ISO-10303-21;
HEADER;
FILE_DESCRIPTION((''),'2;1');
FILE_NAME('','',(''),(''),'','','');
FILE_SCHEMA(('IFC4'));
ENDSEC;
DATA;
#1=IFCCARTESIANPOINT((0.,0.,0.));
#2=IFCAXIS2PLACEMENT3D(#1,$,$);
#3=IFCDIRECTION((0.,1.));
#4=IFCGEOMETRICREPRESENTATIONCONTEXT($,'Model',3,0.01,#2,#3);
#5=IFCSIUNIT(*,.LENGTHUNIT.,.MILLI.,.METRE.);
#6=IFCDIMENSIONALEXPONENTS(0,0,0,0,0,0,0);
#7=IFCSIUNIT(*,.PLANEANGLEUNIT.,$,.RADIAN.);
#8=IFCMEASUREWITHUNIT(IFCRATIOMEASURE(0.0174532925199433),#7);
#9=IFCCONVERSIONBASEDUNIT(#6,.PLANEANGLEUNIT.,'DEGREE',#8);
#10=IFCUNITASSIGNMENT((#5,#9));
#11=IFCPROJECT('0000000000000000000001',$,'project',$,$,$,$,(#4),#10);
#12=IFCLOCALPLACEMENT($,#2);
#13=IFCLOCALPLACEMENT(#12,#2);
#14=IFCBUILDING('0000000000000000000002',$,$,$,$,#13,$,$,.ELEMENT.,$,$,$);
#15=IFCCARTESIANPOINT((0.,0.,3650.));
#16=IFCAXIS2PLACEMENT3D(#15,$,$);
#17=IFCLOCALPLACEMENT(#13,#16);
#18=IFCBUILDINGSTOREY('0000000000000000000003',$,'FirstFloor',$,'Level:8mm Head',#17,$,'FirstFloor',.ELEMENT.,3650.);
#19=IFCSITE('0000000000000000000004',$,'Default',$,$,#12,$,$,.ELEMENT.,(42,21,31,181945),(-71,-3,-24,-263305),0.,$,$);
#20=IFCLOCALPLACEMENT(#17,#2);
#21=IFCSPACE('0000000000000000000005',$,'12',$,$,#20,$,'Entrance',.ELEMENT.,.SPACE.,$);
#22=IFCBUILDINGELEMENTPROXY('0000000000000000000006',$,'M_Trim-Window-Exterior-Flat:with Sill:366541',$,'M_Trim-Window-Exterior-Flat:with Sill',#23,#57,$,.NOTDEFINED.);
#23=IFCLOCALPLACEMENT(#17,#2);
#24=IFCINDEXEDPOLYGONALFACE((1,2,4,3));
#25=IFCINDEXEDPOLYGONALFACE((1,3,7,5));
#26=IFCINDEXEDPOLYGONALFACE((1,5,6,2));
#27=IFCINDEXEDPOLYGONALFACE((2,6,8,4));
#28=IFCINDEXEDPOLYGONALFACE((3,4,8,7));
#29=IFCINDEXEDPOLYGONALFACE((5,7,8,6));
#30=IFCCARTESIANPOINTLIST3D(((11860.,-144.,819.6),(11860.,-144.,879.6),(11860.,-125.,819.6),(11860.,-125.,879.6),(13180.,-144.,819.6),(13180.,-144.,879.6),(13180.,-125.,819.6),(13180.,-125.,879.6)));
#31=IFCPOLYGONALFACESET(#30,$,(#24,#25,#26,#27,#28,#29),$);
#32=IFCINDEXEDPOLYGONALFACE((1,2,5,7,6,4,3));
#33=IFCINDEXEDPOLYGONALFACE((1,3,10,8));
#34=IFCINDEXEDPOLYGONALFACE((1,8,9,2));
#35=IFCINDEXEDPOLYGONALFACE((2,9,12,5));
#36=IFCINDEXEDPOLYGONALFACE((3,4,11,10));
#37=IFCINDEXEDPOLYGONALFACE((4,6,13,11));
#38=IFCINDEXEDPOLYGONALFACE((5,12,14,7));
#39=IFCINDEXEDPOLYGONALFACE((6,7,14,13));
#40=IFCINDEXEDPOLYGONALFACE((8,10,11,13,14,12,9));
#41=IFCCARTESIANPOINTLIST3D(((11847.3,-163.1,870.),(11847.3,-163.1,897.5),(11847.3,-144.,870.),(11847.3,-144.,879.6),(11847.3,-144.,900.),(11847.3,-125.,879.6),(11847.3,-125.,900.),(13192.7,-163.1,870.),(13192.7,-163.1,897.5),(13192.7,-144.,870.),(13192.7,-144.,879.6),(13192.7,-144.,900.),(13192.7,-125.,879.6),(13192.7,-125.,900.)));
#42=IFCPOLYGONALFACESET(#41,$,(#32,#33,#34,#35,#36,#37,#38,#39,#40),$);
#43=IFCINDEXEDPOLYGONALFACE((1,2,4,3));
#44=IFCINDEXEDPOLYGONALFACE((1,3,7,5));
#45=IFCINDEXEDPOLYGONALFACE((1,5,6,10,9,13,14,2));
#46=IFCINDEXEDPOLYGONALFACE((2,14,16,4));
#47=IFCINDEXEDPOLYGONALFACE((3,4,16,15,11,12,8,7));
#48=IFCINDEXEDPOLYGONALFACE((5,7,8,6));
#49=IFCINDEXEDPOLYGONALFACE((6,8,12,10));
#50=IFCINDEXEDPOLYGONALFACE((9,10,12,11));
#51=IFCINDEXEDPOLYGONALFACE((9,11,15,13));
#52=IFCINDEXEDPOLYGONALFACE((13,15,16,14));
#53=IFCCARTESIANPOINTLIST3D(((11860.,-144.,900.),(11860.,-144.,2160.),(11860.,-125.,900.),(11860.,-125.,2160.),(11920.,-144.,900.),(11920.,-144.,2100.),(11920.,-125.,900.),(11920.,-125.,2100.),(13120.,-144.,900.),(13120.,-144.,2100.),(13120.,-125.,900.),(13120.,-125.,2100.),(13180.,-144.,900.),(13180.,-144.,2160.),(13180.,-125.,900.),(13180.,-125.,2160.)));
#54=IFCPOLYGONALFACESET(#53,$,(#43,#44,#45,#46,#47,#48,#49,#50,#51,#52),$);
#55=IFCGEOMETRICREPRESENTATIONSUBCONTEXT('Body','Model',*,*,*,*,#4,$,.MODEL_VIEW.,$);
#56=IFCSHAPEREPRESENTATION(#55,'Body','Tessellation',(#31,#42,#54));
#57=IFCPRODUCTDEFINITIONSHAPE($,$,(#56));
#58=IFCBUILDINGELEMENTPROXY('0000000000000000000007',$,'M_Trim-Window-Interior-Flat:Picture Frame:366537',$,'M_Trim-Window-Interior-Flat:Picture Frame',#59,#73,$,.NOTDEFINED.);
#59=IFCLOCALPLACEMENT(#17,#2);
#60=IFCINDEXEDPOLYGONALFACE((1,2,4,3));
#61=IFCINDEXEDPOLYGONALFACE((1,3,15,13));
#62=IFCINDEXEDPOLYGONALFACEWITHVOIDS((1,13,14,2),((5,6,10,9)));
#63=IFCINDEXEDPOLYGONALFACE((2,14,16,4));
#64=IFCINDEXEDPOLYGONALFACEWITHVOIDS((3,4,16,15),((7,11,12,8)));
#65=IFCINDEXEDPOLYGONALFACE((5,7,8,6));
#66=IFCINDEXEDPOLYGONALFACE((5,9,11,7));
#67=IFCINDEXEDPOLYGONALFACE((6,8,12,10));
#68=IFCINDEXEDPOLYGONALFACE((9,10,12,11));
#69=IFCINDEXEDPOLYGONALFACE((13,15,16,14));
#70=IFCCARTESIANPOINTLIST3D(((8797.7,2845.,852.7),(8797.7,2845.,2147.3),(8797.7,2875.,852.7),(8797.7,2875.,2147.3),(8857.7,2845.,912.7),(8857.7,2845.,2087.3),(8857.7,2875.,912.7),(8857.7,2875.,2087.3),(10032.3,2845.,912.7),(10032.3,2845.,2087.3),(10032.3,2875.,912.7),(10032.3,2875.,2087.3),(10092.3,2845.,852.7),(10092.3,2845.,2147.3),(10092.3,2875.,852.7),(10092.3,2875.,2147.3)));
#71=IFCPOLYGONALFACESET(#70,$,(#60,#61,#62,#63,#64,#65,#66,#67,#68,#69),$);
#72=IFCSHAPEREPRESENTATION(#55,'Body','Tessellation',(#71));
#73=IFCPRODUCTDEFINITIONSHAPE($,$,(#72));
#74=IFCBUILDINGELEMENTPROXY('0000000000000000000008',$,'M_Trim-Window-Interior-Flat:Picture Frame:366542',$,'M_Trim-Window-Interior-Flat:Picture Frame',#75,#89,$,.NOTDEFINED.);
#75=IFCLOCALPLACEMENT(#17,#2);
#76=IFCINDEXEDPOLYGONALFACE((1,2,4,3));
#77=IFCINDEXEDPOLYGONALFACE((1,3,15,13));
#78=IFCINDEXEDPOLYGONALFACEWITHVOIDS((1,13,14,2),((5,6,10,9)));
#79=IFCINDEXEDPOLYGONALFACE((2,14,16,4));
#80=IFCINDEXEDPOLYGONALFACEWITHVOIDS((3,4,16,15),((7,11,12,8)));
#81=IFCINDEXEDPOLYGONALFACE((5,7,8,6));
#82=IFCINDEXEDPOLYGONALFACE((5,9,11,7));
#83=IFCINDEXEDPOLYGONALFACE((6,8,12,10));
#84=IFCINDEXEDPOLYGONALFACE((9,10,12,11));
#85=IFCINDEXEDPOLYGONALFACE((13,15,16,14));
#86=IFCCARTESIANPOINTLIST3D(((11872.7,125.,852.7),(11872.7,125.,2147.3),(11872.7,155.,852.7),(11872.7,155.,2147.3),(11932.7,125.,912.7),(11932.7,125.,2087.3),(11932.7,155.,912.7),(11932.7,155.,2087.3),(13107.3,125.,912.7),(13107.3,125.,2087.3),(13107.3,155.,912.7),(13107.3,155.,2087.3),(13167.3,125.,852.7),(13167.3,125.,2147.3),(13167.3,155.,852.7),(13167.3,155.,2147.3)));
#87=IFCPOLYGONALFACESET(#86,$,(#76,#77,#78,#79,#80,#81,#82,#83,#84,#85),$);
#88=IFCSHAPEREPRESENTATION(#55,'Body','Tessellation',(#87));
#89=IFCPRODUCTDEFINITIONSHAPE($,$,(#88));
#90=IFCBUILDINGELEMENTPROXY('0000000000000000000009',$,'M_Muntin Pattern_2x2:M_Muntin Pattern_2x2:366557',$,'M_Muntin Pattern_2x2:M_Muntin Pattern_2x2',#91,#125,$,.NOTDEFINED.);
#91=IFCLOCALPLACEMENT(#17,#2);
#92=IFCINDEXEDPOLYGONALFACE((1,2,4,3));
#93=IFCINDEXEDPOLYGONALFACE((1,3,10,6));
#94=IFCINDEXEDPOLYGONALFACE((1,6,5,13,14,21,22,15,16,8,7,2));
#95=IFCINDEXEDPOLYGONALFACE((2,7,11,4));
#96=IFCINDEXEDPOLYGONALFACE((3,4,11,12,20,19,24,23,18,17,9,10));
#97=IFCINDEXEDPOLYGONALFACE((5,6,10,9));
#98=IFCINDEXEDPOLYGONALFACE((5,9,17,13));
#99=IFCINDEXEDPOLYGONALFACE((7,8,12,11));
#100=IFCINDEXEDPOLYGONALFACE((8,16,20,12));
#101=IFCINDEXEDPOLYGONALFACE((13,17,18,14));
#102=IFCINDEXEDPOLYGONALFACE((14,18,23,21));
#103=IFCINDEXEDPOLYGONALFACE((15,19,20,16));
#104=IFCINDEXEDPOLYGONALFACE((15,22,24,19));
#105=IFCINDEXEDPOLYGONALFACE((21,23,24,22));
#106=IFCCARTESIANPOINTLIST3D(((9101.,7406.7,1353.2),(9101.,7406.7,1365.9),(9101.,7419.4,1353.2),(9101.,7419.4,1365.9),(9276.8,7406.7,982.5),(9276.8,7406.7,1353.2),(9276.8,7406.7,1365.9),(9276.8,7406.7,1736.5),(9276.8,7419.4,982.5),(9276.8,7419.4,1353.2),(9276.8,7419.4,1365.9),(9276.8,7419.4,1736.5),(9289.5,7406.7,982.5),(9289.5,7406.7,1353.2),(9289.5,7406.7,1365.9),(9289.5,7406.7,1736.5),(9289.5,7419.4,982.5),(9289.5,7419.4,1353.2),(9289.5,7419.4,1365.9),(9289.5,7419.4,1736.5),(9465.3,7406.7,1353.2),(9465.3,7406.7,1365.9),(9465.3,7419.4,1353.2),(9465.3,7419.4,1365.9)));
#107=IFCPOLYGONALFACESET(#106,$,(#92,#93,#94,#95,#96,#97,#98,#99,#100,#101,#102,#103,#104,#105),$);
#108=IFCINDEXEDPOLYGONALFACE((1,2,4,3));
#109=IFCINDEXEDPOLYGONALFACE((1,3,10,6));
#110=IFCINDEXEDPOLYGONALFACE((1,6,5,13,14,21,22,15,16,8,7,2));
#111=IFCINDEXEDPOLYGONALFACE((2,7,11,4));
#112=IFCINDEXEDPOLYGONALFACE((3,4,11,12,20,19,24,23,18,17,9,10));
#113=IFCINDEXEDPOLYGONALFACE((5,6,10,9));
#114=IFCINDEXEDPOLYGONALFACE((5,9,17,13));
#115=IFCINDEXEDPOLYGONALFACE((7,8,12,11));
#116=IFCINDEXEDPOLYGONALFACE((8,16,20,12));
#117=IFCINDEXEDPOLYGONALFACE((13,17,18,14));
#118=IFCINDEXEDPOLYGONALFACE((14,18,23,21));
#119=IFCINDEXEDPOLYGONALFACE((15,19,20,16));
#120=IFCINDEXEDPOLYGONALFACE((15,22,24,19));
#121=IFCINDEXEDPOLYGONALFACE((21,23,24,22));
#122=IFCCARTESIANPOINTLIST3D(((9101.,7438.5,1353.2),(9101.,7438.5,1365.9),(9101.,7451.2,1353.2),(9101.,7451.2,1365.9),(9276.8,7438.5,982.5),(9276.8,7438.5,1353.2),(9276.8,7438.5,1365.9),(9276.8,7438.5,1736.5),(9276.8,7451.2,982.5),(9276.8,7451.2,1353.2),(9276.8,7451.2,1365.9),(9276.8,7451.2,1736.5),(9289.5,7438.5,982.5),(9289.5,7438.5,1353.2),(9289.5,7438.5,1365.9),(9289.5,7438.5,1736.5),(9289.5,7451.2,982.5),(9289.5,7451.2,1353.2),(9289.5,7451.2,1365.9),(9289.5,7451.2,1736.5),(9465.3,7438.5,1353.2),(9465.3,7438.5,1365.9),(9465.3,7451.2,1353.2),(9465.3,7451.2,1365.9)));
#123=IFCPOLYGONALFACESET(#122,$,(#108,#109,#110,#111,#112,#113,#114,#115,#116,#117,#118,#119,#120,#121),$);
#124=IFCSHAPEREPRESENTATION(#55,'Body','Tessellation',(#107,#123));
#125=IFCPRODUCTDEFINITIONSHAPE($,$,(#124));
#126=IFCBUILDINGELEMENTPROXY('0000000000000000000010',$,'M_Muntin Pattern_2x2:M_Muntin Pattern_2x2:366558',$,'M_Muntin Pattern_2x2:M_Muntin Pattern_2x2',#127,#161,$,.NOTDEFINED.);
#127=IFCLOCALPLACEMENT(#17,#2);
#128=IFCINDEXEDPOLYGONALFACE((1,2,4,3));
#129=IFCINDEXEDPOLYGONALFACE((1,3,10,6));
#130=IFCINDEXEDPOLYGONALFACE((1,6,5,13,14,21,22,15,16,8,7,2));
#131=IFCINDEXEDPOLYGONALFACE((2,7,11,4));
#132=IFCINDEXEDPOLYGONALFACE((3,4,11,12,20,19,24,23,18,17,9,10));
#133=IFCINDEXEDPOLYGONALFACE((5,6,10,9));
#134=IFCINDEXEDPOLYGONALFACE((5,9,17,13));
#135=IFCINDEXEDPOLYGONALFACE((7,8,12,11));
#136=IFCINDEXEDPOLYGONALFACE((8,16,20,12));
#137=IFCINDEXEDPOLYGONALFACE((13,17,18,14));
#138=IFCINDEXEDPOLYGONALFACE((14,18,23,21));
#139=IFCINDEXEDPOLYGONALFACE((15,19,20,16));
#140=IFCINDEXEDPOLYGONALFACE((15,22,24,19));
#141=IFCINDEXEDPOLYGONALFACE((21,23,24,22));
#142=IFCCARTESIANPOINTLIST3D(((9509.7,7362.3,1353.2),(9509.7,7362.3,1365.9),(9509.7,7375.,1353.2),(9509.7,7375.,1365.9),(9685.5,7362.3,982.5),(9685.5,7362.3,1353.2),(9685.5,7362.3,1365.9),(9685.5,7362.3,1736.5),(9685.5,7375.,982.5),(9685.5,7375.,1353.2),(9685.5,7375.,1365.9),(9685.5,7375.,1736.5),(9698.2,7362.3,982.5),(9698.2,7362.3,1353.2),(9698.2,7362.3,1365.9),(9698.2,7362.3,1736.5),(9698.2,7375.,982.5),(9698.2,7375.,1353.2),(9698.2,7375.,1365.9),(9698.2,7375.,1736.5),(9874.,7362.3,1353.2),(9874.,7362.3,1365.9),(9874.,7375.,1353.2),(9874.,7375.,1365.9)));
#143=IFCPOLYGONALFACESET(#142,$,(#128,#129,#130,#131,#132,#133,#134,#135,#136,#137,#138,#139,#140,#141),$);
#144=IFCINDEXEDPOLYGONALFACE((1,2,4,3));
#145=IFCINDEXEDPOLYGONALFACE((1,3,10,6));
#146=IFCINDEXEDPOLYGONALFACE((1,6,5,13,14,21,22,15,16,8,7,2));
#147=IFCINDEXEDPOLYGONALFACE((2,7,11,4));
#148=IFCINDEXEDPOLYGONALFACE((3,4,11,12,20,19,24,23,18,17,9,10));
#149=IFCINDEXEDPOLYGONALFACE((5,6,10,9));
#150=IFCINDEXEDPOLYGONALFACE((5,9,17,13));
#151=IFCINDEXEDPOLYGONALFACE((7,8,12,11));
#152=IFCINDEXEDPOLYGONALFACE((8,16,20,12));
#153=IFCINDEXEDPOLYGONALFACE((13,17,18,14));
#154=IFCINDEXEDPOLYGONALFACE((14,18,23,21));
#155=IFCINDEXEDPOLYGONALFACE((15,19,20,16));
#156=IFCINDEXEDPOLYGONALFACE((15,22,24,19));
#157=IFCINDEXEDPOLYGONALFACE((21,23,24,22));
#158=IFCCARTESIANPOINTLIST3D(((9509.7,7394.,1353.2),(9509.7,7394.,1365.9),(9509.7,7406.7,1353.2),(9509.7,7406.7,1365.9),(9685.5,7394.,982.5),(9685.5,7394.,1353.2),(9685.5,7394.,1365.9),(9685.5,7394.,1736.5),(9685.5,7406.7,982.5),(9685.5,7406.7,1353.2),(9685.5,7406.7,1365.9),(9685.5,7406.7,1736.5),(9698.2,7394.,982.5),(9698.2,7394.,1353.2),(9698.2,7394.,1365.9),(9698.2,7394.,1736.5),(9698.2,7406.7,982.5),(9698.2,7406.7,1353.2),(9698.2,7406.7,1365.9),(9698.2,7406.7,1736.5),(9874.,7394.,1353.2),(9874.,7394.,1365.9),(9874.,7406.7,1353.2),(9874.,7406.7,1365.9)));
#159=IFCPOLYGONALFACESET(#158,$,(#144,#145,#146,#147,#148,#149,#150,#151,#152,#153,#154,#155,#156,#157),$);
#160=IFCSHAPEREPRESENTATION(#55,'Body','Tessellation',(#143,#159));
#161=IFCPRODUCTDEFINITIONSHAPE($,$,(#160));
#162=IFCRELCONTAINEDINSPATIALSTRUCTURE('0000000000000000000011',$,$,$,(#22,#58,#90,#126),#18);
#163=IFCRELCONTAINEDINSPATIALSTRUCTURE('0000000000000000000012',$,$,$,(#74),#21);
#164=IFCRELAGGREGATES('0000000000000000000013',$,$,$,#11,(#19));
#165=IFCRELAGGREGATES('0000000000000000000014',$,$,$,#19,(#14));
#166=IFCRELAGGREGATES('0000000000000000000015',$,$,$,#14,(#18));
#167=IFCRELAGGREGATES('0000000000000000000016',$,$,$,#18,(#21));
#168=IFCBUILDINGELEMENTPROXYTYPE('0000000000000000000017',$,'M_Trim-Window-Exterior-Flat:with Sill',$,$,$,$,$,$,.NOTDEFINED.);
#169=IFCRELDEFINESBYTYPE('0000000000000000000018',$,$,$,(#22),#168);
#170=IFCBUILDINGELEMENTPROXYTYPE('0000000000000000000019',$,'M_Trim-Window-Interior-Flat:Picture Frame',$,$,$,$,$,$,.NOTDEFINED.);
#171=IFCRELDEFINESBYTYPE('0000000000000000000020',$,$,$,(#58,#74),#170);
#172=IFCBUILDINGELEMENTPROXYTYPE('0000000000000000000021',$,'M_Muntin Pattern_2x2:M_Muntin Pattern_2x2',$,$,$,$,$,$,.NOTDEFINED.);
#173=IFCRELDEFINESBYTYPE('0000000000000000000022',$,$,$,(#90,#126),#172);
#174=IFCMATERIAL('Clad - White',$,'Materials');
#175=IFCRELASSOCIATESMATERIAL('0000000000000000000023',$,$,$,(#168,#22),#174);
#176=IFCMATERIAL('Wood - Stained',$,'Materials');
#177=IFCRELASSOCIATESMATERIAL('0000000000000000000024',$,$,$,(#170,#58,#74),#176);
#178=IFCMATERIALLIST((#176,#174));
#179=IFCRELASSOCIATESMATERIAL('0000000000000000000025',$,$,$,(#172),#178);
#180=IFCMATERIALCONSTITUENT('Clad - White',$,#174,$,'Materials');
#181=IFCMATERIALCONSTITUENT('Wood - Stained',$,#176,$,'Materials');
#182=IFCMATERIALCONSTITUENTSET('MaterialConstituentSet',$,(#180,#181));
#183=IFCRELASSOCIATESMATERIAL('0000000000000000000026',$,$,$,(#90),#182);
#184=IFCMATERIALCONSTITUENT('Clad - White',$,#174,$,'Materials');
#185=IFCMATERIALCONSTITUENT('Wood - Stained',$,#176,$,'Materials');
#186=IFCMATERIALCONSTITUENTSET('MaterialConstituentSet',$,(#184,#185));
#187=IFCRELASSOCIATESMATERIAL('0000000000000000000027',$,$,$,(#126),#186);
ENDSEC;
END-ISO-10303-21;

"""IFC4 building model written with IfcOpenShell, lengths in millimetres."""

from ifc_helpers import new_model, entity, si_unit, converted_unit, direction, frame, frame_2d, origin, place, context, subcontext, project, spatial, polyline, rectangle, outline, extrude, source, transform, mapped, material, material_list, constituent, constituent_set, type_object, type_shapes, element, save


model = new_model("IFC4")

# Units and contexts
model_context = context("Model", 3, precision=0.01, world=origin(), true_north=direction((0.0, 1.0)))
body_context = subcontext(model_context, "Body", "Model", "MODEL_VIEW")
ifc_project = project(units=[si_unit("LENGTHUNIT", "METRE", prefix="MILLI"), converted_unit("PLANEANGLEUNIT", "DEGREE", entity("IfcRatioMeasure", 0.0174532925199433), si_unit("PLANEANGLEUNIT", "RADIAN"), dimensions=[0, 0, 0, 0, 0, 0, 0])], contexts=[model_context])

# Site, building, storey
site_placement = place(None, origin())
site = spatial("IfcSite", under=ifc_project, at=site_placement, Name="Default", CompositionType="ELEMENT", RefLatitude=(42, 21, 31, 181945), RefLongitude=(-71, -3, -24, -263305), RefElevation=0.0)
building_placement = place(site_placement, origin())
building = spatial("IfcBuilding", under=site, at=building_placement, CompositionType="ELEMENT")
storey_placement = place(building_placement, frame((0.0, 0.0, 3650.0)))
storey = spatial("IfcBuildingStorey", under=building, at=storey_placement, Name="FirstFloor", ObjectType="Level:8mm Head", LongName="FirstFloor", CompositionType="ELEMENT", Elevation=3650.0)

# Shared definitions
ifc_material_1 = material(Name="Clad - White", Category="Materials")
ifc_material_2 = material(Name="Wood - Stained", Category="Materials")

# Building element proxies
building_element_proxy_type_1 = type_object("IfcBuildingElementProxyType", Name="M_Trim-Window-Exterior-Flat:with Sill", PredefinedType="NOTDEFINED", material=ifc_material_1)
shared_shape_1 = source(origin(), body_context, "Body", "SweptSolid", [
    extrude(rectangle(XDim=1320.0, YDim=60.0, at=frame_2d((0.0, 0.0), x_axis=(1.0, 0.0))), frame((0.0, -1250.4, 0.0), z_axis=(0.0, 0.0, 1.0), x_axis=(-1.0, 0.0, 0.0)), (0.0, 0.0, 1.0), 19.1),
    extrude(outline(polyline([(-19.0, -15.2), (0.0, -15.2), (0.0, -5.7), (19.0, -5.7), (19.0, 14.8), (0.0, 14.8), (-19.0, 12.3), (-19.0, -15.2)])), frame((-672.7, -1214.8, 19.0), z_axis=(1.0, 0.0, 0.0), x_axis=(0.0, 0.0, -1.0)), (0.0, 0.0, 1.0), 1345.4),
    extrude(outline(polyline([(-645.0, -660.0), (615.0, -660.0), (615.0, -600.0), (-585.0, -600.0), (-585.0, 600.0), (615.0, 600.0), (615.0, 660.0), (-645.0, 660.0), (-645.0, -660.0)])), frame((0.0, -585.0, 0.0), z_axis=(0.0, 0.0, 1.0), x_axis=(0.0, -1.0, 0.0)), (0.0, 0.0, 1.0), 19.1),
])
type_shapes(building_element_proxy_type_1, [shared_shape_1])
proxy_1_placement = place(storey_placement, frame((12520.0, -125.0, 2100.0), z_axis=(0.0, -1.0, 0.0), x_axis=(1.0, 0.0, 0.0)))
element("IfcBuildingElementProxy", 1, at=proxy_1_placement, inside=storey, type_object=building_element_proxy_type_1, material=ifc_material_1, Name="M_Trim-Window-Exterior-Flat:with Sill:366541", ObjectType="M_Trim-Window-Exterior-Flat:with Sill", PredefinedType="NOTDEFINED", context=body_context, shape_type="MappedRepresentation", body=[
    mapped(shared_shape_1, transform((0.0, 0.0, 0.0), scale=1.0)),
])
building_element_proxy_type_2 = type_object("IfcBuildingElementProxyType", Name="M_Trim-Window-Interior-Flat:Picture Frame", PredefinedType="NOTDEFINED", material=ifc_material_2)
shared_shape_2 = source(origin(), body_context, "Body", "SweptSolid", [
    extrude(outline(polyline([(-647.3, -647.3), (647.3, -647.3), (647.3, 647.3), (-647.3, 647.3), (-647.3, -647.3)]), holes=[polyline([(-587.3, -587.3), (-587.3, 587.3), (587.3, 587.3), (587.3, -587.3), (-587.3, -587.3)])]), frame((0.0, -600.0, 0.0), z_axis=(0.0, 0.0, 1.0), x_axis=(-1.0, 0.0, 0.0)), (0.0, 0.0, 1.0), 30.0),
])
type_shapes(building_element_proxy_type_2, [shared_shape_2])
proxy_2_placement = place(storey_placement, frame((9445.0, 2875.0, 2100.0), z_axis=(0.0, -1.0, 0.0), x_axis=(1.0, 0.0, 0.0)))
element("IfcBuildingElementProxy", 2, at=proxy_2_placement, inside=storey, type_object=building_element_proxy_type_2, material=ifc_material_2, Name="M_Trim-Window-Interior-Flat:Picture Frame:366537", ObjectType="M_Trim-Window-Interior-Flat:Picture Frame", PredefinedType="NOTDEFINED", context=body_context, shape_type="MappedRepresentation", body=[
    mapped(shared_shape_2, transform((0.0, 0.0, 0.0), scale=1.0)),
])

# Shared definitions
space_1_placement = place(storey_placement, origin())
space_1 = spatial("IfcSpace", under=storey, at=space_1_placement, Name="12", LongName="Entrance", CompositionType="ELEMENT", PredefinedType="SPACE")

# Building element proxies
proxy_3_placement = place(space_1_placement, frame((12520.0, 125.0, 2100.0), z_axis=(0.0, 1.0, 0.0), x_axis=(-1.0, 0.0, 0.0)))
element("IfcBuildingElementProxy", 3, at=proxy_3_placement, inside=space_1, type_object=building_element_proxy_type_2, material=ifc_material_2, Name="M_Trim-Window-Interior-Flat:Picture Frame:366542", ObjectType="M_Trim-Window-Interior-Flat:Picture Frame", PredefinedType="NOTDEFINED", context=body_context, shape_type="MappedRepresentation", body=[
    mapped(shared_shape_2, transform((0.0, 0.0, 0.0), scale=1.0)),
])
ifc_constituent_1 = constituent(ifc_material_1, Name="Clad - White", Category="Materials")
ifc_constituent_2 = constituent(ifc_material_2, Name="Wood - Stained", Category="Materials")
ifc_constituent_set_1 = constituent_set(constituents=[ifc_constituent_1, ifc_constituent_2], Name="MaterialConstituentSet")
ifc_material_list_1 = material_list([ifc_material_2, ifc_material_1])
building_element_proxy_type_3 = type_object("IfcBuildingElementProxyType", Name="M_Muntin Pattern_2x2:M_Muntin Pattern_2x2", PredefinedType="NOTDEFINED", material=ifc_material_list_1)
shared_shape_3 = source(origin(), body_context, "Body", "SweptSolid", [
    extrude(outline(polyline([(6.4, -6.4), (377.0, -6.4), (377.0, 6.3), (6.4, 6.3), (6.4, 182.1), (-6.3, 182.1), (-6.3, 6.3), (-377.0, 6.3), (-377.0, -6.4), (-6.3, -6.4), (-6.3, -182.1), (6.4, -182.1), (6.4, -6.4)])), frame((0.0, 9.5, 377.0), z_axis=(0.0, 1.0, 0.0), x_axis=(0.0, 0.0, 1.0)), (0.0, 0.0, 1.0), 12.7),
    extrude(outline(polyline([(6.4, -6.4), (377.0, -6.4), (377.0, 6.3), (6.4, 6.3), (6.4, 182.1), (-6.3, 182.1), (-6.3, 6.3), (-377.0, 6.3), (-377.0, -6.4), (-6.3, -6.4), (-6.3, -182.1), (6.4, -182.1), (6.4, -6.4)])), frame((0.0, -22.2, 377.0), z_axis=(0.0, 1.0, 0.0), x_axis=(0.0, 0.0, 1.0)), (0.0, 0.0, 1.0), 12.7),
])
type_shapes(building_element_proxy_type_3, [shared_shape_3])
proxy_4_placement = place(storey_placement, frame((9283.1, 7429.0, 982.5), z_axis=(0.0, 0.0, 1.0), x_axis=(-1.0, 0.0, 0.0)))
element("IfcBuildingElementProxy", 4, at=proxy_4_placement, inside=storey, type_object=building_element_proxy_type_3, material=ifc_constituent_set_1, Name="M_Muntin Pattern_2x2:M_Muntin Pattern_2x2:366557", ObjectType="M_Muntin Pattern_2x2:M_Muntin Pattern_2x2", PredefinedType="NOTDEFINED", context=body_context, shape_type="MappedRepresentation", body=[
    mapped(shared_shape_3, transform((0.0, 0.0, 0.0), scale=1.0)),
])
ifc_constituent_3 = constituent(ifc_material_1, Name="Clad - White", Category="Materials")
ifc_constituent_4 = constituent(ifc_material_2, Name="Wood - Stained", Category="Materials")
ifc_constituent_set_2 = constituent_set(constituents=[ifc_constituent_3, ifc_constituent_4], Name="MaterialConstituentSet")
proxy_5_placement = place(storey_placement, frame((9691.9, 7384.5, 982.5), z_axis=(0.0, 0.0, 1.0), x_axis=(-1.0, 0.0, 0.0)))
element("IfcBuildingElementProxy", 5, at=proxy_5_placement, inside=storey, type_object=building_element_proxy_type_3, material=ifc_constituent_set_2, Name="M_Muntin Pattern_2x2:M_Muntin Pattern_2x2:366558", ObjectType="M_Muntin Pattern_2x2:M_Muntin Pattern_2x2", PredefinedType="NOTDEFINED", context=body_context, shape_type="MappedRepresentation", body=[
    mapped(shared_shape_3, transform((0.0, 0.0, 0.0), scale=1.0)),
])

save(model, "model.ifc")
